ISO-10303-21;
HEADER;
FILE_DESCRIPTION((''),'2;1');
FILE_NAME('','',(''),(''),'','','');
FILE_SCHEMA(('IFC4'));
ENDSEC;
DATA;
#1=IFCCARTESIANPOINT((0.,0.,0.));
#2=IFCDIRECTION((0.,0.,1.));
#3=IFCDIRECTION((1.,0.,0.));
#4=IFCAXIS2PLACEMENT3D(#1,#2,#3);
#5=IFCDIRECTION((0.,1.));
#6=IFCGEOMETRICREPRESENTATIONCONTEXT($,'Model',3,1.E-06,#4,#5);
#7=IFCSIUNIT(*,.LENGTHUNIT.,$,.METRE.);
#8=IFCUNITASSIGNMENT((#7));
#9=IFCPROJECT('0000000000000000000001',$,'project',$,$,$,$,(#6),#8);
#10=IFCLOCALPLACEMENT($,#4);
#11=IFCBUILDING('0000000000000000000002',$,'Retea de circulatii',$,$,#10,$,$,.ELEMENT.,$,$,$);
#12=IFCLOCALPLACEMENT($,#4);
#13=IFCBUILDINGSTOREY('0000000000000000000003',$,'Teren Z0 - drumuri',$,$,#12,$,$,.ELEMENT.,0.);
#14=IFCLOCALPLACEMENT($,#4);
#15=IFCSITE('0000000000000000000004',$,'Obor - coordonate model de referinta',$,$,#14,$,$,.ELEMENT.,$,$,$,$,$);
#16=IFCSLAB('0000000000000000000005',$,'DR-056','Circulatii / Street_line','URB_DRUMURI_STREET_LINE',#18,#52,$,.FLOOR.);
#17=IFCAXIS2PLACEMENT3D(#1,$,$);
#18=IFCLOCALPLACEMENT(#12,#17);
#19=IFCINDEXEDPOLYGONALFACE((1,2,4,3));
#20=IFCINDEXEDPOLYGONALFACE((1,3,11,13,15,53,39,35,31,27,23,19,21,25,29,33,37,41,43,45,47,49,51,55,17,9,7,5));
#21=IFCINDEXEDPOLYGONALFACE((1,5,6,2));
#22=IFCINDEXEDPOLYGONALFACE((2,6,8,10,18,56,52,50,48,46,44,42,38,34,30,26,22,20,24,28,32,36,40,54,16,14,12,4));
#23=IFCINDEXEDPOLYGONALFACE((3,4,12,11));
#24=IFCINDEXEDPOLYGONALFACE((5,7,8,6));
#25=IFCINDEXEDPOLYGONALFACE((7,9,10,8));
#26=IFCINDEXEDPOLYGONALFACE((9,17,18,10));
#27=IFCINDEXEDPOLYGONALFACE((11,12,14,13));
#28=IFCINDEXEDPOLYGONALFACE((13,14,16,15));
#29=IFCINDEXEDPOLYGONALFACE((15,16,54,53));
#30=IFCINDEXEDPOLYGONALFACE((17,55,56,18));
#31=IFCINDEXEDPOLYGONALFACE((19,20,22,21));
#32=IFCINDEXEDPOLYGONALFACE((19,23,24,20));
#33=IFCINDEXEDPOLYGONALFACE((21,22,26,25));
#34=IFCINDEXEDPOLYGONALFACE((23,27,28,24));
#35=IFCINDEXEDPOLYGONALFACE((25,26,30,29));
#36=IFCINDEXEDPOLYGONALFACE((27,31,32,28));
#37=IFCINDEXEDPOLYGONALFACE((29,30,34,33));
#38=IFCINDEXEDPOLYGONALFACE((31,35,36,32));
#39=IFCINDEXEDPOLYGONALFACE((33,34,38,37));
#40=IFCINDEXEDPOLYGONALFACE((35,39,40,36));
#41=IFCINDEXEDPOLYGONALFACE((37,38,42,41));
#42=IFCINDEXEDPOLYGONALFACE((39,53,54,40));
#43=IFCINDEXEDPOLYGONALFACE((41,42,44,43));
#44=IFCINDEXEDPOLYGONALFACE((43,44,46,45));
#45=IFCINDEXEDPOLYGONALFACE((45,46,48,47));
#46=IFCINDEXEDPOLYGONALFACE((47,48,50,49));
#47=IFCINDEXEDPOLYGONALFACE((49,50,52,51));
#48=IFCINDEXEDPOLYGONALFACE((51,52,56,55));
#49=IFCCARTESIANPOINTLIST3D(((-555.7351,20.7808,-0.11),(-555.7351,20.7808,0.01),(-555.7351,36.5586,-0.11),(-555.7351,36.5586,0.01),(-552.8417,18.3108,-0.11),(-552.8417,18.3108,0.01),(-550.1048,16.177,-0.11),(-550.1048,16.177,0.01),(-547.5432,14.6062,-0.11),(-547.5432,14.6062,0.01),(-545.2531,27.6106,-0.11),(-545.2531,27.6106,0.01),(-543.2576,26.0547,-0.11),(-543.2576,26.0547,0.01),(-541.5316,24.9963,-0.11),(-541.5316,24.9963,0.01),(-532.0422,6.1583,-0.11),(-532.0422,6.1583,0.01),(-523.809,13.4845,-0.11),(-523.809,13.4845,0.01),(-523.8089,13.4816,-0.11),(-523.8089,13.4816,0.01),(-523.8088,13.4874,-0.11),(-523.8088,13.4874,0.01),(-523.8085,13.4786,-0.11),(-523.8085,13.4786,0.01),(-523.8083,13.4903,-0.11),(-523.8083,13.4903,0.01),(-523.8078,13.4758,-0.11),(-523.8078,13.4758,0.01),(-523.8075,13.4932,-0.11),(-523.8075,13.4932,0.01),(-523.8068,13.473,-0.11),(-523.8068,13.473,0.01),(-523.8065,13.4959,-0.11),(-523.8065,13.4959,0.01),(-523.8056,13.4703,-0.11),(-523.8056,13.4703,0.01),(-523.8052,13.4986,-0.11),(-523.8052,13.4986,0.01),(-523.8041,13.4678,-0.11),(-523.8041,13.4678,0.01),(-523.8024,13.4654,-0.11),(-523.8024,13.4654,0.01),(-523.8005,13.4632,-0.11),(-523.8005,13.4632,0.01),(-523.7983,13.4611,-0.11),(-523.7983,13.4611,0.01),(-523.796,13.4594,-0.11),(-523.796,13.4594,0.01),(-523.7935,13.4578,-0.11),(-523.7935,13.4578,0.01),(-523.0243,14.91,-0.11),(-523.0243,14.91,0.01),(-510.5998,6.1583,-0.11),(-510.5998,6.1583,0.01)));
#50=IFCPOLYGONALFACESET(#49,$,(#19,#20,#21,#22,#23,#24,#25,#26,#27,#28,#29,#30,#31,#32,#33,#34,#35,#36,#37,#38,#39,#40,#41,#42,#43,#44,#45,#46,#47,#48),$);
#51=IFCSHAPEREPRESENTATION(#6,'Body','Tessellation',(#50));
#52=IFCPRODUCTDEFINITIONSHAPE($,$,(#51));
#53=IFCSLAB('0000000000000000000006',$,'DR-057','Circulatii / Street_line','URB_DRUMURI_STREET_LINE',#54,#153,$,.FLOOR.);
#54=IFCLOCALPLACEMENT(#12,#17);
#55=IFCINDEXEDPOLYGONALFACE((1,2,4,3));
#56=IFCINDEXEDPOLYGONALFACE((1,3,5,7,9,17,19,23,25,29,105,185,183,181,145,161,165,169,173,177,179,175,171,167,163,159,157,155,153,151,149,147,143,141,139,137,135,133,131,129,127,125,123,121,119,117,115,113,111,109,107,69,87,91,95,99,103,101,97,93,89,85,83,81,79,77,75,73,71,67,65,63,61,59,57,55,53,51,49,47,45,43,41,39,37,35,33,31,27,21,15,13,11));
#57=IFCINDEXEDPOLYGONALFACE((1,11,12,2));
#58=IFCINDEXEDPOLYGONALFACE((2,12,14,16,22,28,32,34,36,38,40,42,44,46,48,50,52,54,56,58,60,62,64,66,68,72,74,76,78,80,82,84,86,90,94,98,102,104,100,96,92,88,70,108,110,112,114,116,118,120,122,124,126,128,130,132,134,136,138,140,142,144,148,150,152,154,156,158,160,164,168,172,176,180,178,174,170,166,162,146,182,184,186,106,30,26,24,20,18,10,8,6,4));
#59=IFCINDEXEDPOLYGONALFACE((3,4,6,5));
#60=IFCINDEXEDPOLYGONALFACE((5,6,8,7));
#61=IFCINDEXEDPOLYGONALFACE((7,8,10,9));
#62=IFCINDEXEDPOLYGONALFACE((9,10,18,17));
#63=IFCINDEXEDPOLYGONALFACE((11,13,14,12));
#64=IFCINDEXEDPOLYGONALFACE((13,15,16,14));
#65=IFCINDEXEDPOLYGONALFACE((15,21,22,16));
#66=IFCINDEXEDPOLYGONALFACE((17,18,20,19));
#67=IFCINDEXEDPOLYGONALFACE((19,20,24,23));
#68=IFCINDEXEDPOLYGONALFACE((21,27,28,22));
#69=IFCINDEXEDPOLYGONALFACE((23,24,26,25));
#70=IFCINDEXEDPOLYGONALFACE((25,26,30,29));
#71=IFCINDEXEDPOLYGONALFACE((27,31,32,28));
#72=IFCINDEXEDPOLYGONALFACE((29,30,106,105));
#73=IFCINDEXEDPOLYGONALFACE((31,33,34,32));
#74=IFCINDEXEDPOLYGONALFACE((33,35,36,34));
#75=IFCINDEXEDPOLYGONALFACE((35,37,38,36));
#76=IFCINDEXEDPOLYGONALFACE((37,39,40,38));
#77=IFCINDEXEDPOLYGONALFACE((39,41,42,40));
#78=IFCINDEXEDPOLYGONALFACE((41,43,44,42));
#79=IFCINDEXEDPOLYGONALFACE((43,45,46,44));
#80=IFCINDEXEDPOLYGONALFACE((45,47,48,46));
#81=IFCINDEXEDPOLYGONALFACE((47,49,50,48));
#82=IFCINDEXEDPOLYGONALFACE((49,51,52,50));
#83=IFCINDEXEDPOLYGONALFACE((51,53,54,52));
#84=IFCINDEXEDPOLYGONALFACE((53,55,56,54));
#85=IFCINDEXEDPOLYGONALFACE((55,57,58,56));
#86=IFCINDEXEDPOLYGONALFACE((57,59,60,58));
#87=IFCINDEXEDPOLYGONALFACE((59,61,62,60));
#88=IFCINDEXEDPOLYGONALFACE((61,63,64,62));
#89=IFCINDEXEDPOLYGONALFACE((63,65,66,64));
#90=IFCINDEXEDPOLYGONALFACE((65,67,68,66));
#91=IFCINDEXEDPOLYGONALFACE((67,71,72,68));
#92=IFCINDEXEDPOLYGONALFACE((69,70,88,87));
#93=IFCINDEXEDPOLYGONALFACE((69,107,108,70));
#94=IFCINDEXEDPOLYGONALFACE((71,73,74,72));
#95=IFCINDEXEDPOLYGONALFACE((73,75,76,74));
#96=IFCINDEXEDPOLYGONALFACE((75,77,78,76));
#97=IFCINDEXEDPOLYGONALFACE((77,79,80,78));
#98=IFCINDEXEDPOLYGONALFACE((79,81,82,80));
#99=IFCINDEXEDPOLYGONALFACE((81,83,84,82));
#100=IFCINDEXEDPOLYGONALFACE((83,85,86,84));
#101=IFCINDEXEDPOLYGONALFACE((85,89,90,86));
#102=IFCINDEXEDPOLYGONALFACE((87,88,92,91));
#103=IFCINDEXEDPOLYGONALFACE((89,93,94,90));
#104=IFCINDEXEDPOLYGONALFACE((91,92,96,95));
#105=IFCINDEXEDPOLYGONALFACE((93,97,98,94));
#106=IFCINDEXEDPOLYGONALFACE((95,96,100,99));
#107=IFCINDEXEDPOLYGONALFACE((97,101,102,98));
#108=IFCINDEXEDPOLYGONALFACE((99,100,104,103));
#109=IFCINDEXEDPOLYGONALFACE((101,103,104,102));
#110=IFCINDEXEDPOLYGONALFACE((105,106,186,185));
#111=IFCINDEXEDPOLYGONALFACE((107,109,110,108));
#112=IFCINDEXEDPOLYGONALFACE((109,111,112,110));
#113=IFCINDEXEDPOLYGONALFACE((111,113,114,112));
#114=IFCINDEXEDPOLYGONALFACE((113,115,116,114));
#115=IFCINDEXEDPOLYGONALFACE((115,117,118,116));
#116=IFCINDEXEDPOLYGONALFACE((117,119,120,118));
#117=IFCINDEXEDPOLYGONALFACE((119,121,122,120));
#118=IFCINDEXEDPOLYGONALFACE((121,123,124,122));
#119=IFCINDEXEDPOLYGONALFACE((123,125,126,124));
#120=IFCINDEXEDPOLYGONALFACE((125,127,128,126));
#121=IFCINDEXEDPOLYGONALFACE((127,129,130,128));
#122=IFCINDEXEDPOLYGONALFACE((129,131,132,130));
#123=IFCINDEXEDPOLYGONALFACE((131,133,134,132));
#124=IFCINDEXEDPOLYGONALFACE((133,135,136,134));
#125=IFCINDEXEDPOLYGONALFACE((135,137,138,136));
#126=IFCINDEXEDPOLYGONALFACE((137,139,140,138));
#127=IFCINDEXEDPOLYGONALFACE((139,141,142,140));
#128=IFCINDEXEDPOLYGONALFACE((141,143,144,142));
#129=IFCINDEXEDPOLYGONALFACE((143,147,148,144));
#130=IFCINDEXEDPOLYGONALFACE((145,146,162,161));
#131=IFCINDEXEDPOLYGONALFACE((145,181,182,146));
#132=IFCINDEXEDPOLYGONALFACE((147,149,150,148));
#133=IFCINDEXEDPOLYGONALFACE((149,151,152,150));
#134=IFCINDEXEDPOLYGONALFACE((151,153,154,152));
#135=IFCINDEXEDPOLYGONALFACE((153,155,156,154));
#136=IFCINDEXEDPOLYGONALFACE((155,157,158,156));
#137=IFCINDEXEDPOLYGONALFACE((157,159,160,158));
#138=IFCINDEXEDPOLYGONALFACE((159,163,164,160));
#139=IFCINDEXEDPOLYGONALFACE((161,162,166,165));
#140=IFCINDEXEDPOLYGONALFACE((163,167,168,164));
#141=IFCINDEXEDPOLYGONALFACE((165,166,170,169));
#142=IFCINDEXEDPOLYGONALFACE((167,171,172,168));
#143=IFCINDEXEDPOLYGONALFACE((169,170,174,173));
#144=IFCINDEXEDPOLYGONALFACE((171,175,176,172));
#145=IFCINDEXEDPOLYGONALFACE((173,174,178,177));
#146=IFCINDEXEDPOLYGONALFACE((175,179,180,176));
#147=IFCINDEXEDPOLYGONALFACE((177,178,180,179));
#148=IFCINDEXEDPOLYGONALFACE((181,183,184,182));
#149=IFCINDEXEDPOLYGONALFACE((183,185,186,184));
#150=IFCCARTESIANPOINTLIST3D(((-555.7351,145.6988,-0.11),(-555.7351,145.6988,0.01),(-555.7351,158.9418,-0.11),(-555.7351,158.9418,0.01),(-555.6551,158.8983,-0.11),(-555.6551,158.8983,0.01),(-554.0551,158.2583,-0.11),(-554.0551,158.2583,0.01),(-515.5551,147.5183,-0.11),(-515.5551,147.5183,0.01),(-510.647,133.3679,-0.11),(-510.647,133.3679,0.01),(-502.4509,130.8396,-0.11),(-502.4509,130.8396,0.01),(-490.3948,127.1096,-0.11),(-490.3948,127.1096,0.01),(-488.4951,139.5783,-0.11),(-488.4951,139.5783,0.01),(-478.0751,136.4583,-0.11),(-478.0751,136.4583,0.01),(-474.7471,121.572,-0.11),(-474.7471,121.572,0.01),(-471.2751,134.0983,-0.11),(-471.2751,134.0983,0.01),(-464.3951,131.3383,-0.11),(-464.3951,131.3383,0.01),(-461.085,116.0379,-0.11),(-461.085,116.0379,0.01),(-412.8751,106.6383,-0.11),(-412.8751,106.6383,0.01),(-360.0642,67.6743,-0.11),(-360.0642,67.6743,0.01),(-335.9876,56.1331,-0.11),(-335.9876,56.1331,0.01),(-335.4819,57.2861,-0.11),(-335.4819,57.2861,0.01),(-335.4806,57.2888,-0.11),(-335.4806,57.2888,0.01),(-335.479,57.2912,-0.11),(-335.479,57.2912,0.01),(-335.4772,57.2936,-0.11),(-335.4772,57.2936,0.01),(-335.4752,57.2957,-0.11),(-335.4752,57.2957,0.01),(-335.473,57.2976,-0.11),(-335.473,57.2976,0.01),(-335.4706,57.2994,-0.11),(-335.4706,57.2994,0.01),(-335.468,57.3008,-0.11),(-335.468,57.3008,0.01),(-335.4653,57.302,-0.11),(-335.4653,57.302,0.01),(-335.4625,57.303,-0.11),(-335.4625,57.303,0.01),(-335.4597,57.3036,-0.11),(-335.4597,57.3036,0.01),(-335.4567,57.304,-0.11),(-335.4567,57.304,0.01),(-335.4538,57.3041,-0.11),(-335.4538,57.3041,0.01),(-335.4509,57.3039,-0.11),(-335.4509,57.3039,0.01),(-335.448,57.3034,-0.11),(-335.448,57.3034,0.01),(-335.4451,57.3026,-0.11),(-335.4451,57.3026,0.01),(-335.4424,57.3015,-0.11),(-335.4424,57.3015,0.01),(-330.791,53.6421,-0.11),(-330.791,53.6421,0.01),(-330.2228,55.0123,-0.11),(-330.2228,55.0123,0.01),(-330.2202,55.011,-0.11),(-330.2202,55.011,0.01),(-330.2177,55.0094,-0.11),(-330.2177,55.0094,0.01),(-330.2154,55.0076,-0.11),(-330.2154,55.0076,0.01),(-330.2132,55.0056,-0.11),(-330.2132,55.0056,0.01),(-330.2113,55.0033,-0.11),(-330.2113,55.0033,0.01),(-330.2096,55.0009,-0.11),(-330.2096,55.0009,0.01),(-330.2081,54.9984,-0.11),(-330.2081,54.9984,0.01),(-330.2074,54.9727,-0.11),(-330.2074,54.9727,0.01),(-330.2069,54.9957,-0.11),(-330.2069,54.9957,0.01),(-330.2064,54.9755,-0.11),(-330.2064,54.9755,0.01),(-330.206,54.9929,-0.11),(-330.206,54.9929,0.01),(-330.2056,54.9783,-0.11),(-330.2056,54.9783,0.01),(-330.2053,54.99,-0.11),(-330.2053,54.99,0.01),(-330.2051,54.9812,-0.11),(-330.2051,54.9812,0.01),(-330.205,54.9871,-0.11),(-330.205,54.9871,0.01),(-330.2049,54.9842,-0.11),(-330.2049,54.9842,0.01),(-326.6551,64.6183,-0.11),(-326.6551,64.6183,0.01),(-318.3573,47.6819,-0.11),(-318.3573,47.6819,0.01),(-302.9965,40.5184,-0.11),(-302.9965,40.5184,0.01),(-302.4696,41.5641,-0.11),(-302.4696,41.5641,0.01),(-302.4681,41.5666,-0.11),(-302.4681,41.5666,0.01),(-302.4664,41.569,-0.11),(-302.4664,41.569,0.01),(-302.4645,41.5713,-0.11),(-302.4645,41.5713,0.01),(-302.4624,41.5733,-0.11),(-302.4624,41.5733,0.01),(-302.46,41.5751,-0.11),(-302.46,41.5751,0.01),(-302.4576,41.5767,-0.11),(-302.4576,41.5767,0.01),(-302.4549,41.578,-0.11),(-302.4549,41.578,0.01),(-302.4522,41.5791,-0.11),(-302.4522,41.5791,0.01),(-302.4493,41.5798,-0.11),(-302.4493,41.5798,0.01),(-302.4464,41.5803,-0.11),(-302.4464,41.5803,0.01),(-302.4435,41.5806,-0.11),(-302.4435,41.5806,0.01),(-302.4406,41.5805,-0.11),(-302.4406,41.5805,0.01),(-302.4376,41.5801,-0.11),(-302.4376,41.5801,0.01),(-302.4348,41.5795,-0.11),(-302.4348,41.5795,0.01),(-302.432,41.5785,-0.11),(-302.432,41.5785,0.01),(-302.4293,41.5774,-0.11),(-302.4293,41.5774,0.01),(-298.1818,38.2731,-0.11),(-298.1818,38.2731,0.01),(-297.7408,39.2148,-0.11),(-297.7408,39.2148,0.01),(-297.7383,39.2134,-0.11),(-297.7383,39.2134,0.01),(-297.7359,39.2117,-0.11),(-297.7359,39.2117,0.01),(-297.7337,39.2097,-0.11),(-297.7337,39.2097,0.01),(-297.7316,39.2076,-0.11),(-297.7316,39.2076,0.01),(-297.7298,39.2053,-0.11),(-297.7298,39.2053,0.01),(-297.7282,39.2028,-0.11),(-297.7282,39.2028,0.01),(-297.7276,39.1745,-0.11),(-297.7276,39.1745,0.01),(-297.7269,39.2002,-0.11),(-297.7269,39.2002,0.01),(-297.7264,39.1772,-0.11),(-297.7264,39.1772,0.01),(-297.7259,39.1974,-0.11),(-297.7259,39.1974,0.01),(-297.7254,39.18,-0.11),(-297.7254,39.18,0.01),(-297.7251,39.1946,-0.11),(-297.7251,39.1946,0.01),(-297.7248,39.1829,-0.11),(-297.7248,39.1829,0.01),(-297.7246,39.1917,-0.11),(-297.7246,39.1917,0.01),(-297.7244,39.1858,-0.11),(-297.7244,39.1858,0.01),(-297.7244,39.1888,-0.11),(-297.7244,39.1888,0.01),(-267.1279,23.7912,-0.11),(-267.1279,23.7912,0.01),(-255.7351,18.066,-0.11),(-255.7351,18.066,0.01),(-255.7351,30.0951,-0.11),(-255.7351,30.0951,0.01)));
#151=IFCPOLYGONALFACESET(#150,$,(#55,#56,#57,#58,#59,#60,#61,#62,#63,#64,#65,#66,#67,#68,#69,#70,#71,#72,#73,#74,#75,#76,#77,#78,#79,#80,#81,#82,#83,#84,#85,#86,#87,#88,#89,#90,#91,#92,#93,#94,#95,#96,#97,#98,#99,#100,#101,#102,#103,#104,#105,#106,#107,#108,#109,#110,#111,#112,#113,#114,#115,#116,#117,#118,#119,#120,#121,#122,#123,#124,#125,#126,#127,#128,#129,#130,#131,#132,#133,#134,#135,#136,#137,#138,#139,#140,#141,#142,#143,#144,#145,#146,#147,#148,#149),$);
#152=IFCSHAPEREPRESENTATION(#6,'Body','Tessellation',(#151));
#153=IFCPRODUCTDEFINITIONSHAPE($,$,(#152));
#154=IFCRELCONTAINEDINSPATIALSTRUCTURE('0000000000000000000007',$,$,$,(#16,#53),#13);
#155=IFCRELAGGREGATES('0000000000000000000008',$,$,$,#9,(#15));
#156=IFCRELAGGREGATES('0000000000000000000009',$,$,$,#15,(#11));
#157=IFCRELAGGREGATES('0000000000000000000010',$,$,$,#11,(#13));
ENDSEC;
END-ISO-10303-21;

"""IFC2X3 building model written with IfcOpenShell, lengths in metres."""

from ifc_helpers import new_model, si_unit, direction, frame, origin_with_axes, place, context, project, spatial, polyline, outline, extrude, element, save


model = new_model("IFC2X3")

# Units and contexts
model_context = context("Model", 3, precision=1e-06, world=origin_with_axes(), true_north=direction((0.0, 1.0)))
ifc_project = project(units=[si_unit("LENGTHUNIT", "METRE")], contexts=[model_context])

# Site, building, storey
site_placement = place(None, origin_with_axes())
site = spatial("IfcSite", under=ifc_project, at=site_placement, Name="Obor - coordonate model de referinta", CompositionType="ELEMENT")
building_placement = place(None, origin_with_axes())
building = spatial("IfcBuilding", under=site, at=building_placement, Name="Retea de circulatii", CompositionType="ELEMENT")
storey_placement = place(None, origin_with_axes())
storey = spatial("IfcBuildingStorey", under=building, at=storey_placement, Name="Teren Z0 - drumuri", CompositionType="ELEMENT", Elevation=0.0)

# Slabs
slab_1_placement = place(None, origin_with_axes())
element("IfcSlab", 1, at=slab_1_placement, inside=storey, Name="DR-056", Description="Circulatii / Street_line", ObjectType="URB_DRUMURI_STREET_LINE", PredefinedType="FLOOR", context=model_context, shape_type="SweptSolid", body=[
    extrude(outline(polyline([(-552.8417, 18.3108), (-550.1048, 16.177), (-547.5432, 14.6062), (-532.0422, 6.1583), (-510.5998, 6.1583), (-523.7935, 13.4578), (-523.796, 13.4594), (-523.7983, 13.4611), (-523.8005, 13.4632), (-523.8024, 13.4654), (-523.8041, 13.4678), (-523.8056, 13.4703), (-523.8068, 13.473), (-523.8078, 13.4758), (-523.8085, 13.4786), (-523.8089, 13.4816), (-523.809, 13.4845), (-523.8088, 13.4874), (-523.8083, 13.4903), (-523.8075, 13.4932), (-523.8065, 13.4959), (-523.8052, 13.4986), (-523.0243, 14.91), (-541.5316, 24.9963), (-543.2576, 26.0547), (-545.2531, 27.6106), (-555.7351, 36.5586), (-555.7351, 20.7808), (-552.8417, 18.3108)])), frame((0.0, 0.0, -0.11), z_axis=(0.0, 0.0, 1.0), x_axis=(1.0, 0.0, 0.0)), (0.0, 0.0, 1.0), 0.12),
])
slab_2_placement = place(None, origin_with_axes())
element("IfcSlab", 2, at=slab_2_placement, inside=storey, Name="DR-057", Description="Circulatii / Street_line", ObjectType="URB_DRUMURI_STREET_LINE", PredefinedType="FLOOR", context=model_context, shape_type="SweptSolid", body=[
    extrude(outline(polyline([(-297.7276, 39.1745), (-298.1818, 38.2731), (-267.1279, 23.7912), (-255.7351, 18.066), (-255.7351, 30.0951), (-326.6551, 64.6183), (-412.8751, 106.6383), (-464.3951, 131.3383), (-471.2751, 134.0983), (-478.0751, 136.4583), (-488.4951, 139.5783), (-515.5551, 147.5183), (-554.0551, 158.2583), (-555.6551, 158.8983), (-555.7351, 158.9418), (-555.7351, 145.6988), (-510.647, 133.3679), (-502.4509, 130.8396), (-490.3948, 127.1096), (-474.7471, 121.572), (-461.085, 116.0379), (-360.0642, 67.6743), (-335.9876, 56.1331), (-335.4819, 57.2861), (-335.4806, 57.2888), (-335.479, 57.2912), (-335.4772, 57.2936), (-335.4752, 57.2957), (-335.473, 57.2976), (-335.4706, 57.2994), (-335.468, 57.3008), (-335.4653, 57.302), (-335.4625, 57.303), (-335.4597, 57.3036), (-335.4567, 57.304), (-335.4538, 57.3041), (-335.4509, 57.3039), (-335.448, 57.3034), (-335.4451, 57.3026), (-335.4424, 57.3015), (-330.2228, 55.0123), (-330.2202, 55.011), (-330.2177, 55.0094), (-330.2154, 55.0076), (-330.2132, 55.0056), (-330.2113, 55.0033), (-330.2096, 55.0009), (-330.2081, 54.9984), (-330.2069, 54.9957), (-330.206, 54.9929), (-330.2053, 54.99), (-330.205, 54.9871), (-330.2049, 54.9842), (-330.2051, 54.9812), (-330.2056, 54.9783), (-330.2064, 54.9755), (-330.2074, 54.9727), (-330.791, 53.6421), (-318.3573, 47.6819), (-302.9965, 40.5184), (-302.4696, 41.5641), (-302.4681, 41.5666), (-302.4664, 41.569), (-302.4645, 41.5713), (-302.4624, 41.5733), (-302.46, 41.5751), (-302.4576, 41.5767), (-302.4549, 41.578), (-302.4522, 41.5791), (-302.4493, 41.5798), (-302.4464, 41.5803), (-302.4435, 41.5806), (-302.4406, 41.5805), (-302.4376, 41.5801), (-302.4348, 41.5795), (-302.432, 41.5785), (-302.4293, 41.5774), (-297.7408, 39.2148), (-297.7383, 39.2134), (-297.7359, 39.2117), (-297.7337, 39.2097), (-297.7316, 39.2076), (-297.7298, 39.2053), (-297.7282, 39.2028), (-297.7269, 39.2002), (-297.7259, 39.1974), (-297.7251, 39.1946), (-297.7246, 39.1917), (-297.7244, 39.1888), (-297.7244, 39.1858), (-297.7248, 39.1829), (-297.7254, 39.18), (-297.7264, 39.1772), (-297.7276, 39.1745)])), frame((0.0, 0.0, -0.11), z_axis=(0.0, 0.0, 1.0), x_axis=(1.0, 0.0, 0.0)), (0.0, 0.0, 1.0), 0.12),
])

save(model, "model.ifc")
